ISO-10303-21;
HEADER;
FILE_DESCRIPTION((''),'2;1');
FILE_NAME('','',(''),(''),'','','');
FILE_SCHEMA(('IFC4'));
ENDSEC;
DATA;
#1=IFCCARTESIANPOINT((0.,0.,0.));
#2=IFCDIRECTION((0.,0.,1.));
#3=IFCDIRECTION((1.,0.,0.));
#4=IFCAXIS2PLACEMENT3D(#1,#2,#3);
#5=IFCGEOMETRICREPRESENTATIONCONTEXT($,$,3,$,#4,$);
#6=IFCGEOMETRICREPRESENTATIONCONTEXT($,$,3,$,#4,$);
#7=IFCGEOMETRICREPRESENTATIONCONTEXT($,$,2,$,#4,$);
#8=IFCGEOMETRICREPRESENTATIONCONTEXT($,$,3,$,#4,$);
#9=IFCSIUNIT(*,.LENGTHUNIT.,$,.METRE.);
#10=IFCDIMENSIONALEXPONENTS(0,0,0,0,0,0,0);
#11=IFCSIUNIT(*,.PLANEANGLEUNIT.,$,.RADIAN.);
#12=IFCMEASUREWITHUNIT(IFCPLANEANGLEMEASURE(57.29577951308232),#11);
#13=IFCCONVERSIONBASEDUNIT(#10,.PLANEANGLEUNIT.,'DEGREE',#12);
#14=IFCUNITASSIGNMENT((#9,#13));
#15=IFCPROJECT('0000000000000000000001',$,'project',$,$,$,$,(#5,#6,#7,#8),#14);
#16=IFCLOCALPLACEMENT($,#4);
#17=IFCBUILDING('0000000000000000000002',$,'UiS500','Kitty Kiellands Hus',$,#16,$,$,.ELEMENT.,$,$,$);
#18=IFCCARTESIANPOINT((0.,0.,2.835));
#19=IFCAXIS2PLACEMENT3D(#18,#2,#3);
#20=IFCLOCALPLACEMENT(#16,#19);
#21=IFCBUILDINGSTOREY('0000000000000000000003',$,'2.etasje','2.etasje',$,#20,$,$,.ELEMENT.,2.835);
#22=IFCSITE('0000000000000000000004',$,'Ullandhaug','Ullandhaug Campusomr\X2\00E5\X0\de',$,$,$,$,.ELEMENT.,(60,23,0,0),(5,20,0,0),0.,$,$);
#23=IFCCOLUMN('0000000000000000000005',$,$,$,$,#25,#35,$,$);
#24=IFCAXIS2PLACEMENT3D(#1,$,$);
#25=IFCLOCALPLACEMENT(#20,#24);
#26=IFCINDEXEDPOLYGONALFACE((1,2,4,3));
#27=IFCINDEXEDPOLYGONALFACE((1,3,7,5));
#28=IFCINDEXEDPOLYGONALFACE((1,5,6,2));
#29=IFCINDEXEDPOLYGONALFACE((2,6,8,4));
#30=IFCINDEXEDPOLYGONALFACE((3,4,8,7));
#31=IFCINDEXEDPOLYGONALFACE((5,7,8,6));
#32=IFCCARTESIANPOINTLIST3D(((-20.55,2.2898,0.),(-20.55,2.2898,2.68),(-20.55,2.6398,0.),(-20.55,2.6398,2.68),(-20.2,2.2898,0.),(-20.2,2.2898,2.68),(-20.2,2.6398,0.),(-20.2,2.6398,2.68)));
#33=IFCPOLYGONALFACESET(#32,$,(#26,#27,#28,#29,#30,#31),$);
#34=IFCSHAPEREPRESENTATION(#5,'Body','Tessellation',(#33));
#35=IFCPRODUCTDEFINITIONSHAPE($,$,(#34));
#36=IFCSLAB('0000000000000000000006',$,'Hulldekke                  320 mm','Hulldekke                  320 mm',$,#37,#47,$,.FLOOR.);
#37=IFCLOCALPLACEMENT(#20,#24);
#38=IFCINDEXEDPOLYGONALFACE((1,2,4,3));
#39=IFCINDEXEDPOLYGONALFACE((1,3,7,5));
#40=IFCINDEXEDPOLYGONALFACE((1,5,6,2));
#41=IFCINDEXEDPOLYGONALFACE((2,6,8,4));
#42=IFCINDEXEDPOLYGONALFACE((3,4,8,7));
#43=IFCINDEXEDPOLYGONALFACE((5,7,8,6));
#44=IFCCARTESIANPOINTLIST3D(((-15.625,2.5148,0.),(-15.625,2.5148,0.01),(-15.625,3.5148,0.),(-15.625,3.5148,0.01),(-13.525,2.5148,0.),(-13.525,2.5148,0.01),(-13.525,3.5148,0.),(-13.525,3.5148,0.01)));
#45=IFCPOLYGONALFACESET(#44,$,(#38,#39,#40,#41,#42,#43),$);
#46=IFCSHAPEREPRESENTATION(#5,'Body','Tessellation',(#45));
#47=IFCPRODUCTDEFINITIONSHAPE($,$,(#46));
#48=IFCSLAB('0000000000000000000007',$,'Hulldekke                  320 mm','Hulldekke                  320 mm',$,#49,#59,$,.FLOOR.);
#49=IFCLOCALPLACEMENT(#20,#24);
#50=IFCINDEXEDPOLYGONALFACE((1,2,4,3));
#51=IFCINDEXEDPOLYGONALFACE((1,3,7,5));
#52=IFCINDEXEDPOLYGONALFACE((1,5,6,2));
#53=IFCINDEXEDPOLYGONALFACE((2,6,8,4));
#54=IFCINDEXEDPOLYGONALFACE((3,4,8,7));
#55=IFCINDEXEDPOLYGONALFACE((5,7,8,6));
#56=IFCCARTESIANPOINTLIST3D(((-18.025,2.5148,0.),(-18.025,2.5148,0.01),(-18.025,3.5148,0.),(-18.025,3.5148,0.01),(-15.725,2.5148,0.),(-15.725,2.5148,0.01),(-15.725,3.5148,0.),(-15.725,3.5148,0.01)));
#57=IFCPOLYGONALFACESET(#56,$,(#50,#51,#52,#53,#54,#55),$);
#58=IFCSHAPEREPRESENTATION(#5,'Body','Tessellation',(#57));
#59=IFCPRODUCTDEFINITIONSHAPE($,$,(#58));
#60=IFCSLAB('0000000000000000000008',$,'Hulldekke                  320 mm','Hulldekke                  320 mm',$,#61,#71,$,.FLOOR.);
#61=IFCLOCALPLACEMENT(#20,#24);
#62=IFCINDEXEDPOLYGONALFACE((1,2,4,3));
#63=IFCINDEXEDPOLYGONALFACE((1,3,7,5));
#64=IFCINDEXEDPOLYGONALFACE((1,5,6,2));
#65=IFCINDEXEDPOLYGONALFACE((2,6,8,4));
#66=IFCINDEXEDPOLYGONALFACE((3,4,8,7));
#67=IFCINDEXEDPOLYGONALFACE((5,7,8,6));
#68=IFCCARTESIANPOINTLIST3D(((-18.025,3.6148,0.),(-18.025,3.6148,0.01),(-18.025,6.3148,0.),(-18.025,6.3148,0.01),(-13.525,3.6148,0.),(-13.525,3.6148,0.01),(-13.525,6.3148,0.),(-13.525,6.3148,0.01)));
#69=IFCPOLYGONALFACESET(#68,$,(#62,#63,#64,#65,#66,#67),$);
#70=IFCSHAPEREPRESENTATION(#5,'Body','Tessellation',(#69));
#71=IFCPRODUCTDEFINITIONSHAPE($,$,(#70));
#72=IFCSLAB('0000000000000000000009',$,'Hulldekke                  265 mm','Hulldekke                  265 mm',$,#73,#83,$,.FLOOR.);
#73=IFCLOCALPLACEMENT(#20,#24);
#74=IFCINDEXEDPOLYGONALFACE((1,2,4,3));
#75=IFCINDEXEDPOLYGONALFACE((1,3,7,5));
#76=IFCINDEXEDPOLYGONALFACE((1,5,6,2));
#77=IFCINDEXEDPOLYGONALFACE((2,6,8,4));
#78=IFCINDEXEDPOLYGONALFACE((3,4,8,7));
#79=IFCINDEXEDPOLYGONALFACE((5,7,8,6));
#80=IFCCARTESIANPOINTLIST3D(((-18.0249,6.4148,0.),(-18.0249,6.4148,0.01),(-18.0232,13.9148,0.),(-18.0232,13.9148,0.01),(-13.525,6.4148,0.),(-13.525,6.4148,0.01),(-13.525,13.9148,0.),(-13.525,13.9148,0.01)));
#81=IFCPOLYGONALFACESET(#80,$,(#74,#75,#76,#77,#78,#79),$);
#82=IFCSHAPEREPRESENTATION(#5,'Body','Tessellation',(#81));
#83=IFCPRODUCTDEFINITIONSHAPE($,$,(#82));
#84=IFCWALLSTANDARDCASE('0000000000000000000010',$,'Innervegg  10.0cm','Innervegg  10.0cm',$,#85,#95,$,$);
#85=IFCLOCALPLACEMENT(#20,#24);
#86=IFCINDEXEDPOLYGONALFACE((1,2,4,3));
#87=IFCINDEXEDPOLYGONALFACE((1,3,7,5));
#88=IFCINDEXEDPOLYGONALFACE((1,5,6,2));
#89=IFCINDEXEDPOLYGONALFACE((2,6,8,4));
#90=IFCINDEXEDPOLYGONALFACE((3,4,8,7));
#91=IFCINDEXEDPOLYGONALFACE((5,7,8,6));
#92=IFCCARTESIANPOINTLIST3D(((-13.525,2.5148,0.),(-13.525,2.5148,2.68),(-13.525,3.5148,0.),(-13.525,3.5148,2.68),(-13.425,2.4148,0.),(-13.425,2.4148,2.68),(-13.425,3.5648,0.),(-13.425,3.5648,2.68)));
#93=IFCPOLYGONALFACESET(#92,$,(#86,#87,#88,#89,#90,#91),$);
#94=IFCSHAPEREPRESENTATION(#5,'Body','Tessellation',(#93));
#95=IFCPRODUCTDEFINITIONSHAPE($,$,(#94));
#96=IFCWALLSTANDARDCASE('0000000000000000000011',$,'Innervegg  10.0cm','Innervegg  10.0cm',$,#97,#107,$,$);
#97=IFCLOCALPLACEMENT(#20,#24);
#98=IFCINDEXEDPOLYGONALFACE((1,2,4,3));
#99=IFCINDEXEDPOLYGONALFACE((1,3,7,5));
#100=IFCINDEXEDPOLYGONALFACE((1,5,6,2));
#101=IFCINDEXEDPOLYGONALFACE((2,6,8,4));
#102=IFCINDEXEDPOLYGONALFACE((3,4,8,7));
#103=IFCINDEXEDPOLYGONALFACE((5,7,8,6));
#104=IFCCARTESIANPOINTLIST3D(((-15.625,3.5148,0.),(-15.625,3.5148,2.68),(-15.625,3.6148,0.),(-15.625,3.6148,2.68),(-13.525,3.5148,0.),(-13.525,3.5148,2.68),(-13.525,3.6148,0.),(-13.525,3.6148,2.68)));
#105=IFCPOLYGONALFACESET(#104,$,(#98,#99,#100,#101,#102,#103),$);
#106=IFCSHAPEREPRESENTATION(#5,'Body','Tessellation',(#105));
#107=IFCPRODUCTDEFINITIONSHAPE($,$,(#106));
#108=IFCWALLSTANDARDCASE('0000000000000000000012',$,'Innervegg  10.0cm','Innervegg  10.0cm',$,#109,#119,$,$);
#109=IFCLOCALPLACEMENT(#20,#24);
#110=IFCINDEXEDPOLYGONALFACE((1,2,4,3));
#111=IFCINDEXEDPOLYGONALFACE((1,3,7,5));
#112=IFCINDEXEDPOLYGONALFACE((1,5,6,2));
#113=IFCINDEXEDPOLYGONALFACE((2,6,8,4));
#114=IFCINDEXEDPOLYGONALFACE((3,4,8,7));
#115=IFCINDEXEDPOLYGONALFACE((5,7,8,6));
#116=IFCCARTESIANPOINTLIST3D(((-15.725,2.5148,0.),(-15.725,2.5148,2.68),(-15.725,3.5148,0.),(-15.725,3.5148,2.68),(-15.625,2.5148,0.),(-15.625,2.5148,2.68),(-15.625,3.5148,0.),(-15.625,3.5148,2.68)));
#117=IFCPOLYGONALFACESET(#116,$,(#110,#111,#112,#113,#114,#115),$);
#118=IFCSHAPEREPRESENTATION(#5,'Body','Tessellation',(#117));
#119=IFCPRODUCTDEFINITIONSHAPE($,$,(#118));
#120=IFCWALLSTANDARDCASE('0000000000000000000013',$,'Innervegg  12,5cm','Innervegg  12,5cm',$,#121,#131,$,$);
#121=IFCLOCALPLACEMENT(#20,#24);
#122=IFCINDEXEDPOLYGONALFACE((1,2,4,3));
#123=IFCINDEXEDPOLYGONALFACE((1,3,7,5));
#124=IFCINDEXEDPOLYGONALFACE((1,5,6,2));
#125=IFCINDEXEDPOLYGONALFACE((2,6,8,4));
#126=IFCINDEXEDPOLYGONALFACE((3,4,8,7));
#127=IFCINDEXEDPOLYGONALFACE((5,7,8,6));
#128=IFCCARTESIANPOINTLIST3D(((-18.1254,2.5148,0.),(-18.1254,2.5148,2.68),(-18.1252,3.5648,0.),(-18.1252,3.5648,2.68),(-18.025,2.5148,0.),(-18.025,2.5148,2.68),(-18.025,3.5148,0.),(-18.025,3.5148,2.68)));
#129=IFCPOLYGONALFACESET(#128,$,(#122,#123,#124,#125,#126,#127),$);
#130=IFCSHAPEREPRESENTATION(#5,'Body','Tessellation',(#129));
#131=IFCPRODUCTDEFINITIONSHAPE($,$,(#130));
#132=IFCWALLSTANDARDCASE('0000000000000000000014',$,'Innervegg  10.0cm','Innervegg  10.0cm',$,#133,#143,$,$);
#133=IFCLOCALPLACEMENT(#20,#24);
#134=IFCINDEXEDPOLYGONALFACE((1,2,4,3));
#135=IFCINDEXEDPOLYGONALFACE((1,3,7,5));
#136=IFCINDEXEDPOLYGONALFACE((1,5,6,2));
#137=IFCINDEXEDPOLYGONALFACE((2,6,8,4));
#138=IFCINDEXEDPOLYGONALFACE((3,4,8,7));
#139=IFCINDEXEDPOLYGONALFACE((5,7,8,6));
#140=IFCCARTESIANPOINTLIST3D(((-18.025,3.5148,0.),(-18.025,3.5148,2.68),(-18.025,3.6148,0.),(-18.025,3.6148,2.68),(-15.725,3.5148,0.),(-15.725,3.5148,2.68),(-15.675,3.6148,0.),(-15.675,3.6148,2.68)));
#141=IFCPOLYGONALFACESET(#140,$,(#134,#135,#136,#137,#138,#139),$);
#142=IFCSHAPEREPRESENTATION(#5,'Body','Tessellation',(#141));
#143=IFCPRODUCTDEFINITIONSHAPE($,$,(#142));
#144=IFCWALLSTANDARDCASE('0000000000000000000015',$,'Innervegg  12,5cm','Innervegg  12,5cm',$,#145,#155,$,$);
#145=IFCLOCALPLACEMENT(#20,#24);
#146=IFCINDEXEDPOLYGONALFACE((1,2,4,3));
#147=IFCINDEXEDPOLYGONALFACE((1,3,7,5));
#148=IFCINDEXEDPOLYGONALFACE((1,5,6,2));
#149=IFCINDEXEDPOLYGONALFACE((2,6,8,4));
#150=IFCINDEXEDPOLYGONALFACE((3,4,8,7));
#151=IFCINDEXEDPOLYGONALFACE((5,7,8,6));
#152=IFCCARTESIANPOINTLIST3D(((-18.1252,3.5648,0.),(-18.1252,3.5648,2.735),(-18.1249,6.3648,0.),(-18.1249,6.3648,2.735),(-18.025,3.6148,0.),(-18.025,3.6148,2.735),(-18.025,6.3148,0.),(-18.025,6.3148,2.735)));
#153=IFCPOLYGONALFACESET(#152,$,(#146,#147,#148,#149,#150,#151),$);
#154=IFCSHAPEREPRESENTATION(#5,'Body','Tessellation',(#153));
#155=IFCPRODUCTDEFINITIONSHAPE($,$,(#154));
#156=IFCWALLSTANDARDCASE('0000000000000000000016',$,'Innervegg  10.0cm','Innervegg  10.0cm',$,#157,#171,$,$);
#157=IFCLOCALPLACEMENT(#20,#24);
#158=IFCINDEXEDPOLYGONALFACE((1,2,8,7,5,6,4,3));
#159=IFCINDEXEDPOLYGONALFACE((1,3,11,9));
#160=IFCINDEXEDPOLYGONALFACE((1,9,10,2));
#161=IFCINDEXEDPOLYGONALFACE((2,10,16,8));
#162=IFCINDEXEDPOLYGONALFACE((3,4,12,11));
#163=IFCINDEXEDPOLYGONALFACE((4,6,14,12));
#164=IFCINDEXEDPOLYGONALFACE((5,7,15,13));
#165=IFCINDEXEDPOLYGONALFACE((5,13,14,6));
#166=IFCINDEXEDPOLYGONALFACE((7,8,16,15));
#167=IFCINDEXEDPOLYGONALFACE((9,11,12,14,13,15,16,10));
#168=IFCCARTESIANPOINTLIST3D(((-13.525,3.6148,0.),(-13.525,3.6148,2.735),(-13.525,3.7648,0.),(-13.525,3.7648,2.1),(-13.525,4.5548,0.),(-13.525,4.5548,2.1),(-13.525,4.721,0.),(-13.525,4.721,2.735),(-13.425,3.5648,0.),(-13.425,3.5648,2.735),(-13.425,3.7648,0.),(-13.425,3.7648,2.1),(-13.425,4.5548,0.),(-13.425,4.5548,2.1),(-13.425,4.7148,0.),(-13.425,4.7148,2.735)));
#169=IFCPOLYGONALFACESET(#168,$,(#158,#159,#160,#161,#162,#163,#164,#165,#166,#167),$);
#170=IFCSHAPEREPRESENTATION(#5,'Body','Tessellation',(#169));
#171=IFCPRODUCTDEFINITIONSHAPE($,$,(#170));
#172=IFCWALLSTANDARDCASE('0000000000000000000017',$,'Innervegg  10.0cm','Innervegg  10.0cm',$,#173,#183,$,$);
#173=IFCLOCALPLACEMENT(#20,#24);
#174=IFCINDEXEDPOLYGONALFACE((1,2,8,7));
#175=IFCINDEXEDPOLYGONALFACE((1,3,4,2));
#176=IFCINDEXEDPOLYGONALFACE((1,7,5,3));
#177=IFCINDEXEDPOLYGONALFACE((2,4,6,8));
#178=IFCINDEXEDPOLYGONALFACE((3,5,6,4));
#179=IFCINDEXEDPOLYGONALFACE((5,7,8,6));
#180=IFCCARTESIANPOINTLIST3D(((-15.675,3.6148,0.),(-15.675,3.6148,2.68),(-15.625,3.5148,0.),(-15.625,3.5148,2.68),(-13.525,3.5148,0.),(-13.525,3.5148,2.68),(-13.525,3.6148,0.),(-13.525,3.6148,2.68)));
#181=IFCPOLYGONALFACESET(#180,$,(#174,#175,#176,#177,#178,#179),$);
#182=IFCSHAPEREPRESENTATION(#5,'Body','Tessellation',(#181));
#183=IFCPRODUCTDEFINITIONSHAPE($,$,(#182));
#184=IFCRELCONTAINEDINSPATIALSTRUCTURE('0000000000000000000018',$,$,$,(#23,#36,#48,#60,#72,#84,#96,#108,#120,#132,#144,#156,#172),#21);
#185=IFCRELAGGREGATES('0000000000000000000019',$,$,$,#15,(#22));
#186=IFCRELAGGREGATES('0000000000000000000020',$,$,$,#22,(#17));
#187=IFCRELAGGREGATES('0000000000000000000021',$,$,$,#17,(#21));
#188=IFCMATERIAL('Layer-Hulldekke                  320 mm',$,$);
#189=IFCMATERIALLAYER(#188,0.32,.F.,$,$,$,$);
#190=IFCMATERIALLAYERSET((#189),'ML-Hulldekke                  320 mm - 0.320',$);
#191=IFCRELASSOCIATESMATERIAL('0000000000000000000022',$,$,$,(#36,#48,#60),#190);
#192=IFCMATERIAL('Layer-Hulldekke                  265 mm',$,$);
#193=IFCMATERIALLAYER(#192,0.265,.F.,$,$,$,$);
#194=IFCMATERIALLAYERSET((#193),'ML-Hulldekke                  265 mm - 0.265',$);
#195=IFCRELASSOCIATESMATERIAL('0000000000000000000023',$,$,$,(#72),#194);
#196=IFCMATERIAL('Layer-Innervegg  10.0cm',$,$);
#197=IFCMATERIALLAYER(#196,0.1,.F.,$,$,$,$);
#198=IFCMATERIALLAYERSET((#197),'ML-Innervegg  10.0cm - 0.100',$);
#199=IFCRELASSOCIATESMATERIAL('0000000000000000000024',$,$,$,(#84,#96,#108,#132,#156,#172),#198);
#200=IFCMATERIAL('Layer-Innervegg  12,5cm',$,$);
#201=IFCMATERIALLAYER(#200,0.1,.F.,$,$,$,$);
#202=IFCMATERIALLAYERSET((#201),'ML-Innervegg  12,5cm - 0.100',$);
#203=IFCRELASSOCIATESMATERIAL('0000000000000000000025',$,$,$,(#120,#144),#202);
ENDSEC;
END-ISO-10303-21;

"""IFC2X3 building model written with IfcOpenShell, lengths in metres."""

from ifc_helpers import new_model, entity, si_unit, converted_unit, frame, origin_with_axes, origin_2d_with_axis, place, context, project, spatial, polyline, rectangle, outline, extrude, material, layer, layer_set, layer_usage, element, save


model = new_model("IFC2X3")

# Units and contexts
context_of_model_1 = context(None, 3, world=origin_with_axes())
context_of_model_2 = context(None, 3, world=origin_with_axes())
context_of_model_3 = context(None, 2, world=origin_with_axes())
context_of_model_4 = context(None, 3, world=origin_with_axes())
ifc_project = project(units=[si_unit("LENGTHUNIT", "METRE"), converted_unit("PLANEANGLEUNIT", "DEGREE", entity("IfcPlaneAngleMeasure", 57.29577951308232), si_unit("PLANEANGLEUNIT", "RADIAN"), dimensions=[0, 0, 0, 0, 0, 0, 0])], contexts=[context_of_model_1, context_of_model_2, context_of_model_3, context_of_model_4])

# Site, building, storey
site = spatial("IfcSite", under=ifc_project, Name="Ullandhaug", Description="Ullandhaug Campusområde", CompositionType="ELEMENT", RefLatitude=(60, 23, 0, 0), RefLongitude=(5, 20, 0, 0), RefElevation=0.0)
building_placement = place(None, origin_with_axes())
building = spatial("IfcBuilding", under=site, at=building_placement, Name="UiS500", Description="Kitty Kiellands Hus", CompositionType="ELEMENT")
storey_placement = place(building_placement, frame((0.0, 0.0, 2.835), z_axis=(0.0, 0.0, 1.0), x_axis=(1.0, 0.0, 0.0)))
storey = spatial("IfcBuildingStorey", under=building, at=storey_placement, Name="2.etasje", Description="2.etasje", CompositionType="ELEMENT", Elevation=2.835)

# Column
column_placement = place(storey_placement, frame((-20.375, 2.4648, 0.0), z_axis=(0.0, 0.0, 1.0), x_axis=(1.0, 0.0, 0.0)))
element("IfcColumn", 1, at=column_placement, inside=storey, context=context_of_model_1, shape_type="SweptSolid", body=[
    extrude(rectangle(XDim=0.35, YDim=0.35, at=origin_2d_with_axis()), origin_with_axes(), (0.0, 0.0, 1.0), 2.68),
])

# Slabs
ifc_material_1 = material(Name="Layer-Hulldekke                  320 mm")
ifc_layer_1 = layer(ifc_material_1, 0.32, ventilated=False)
ifc_layer_set_1 = layer_set([ifc_layer_1], Name="ML-Hulldekke                  320 mm - 0.320")
ifc_layer_usage_1 = layer_usage(ifc_layer_set_1, "AXIS2", "POSITIVE", 0.0)
slab_1_placement = place(storey_placement, frame((-15.625, 2.5148, 0.0), z_axis=(0.0, 0.0, 1.0), x_axis=(1.0, 0.0, 0.0)))
element("IfcSlab", 2, at=slab_1_placement, inside=storey, material=ifc_layer_usage_1, Name="Hulldekke                  320 mm", Description="Hulldekke                  320 mm", PredefinedType="FLOOR", context=context_of_model_1, shape_type="SweptSolid", body=[
    extrude(outline(polyline([(0.0, 0.0), (2.1, 0.0), (2.1, 1.0), (0.0, 1.0), (0.0, 0.0)])), origin_with_axes(), (0.0, 0.0, 1.0), 0.01),
])
slab_2_placement = place(storey_placement, frame((-18.025, 3.5148, 0.0), z_axis=(0.0, 0.0, 1.0), x_axis=(1.0, 0.0, 0.0)))
element("IfcSlab", 3, at=slab_2_placement, inside=storey, material=ifc_layer_usage_1, Name="Hulldekke                  320 mm", Description="Hulldekke                  320 mm", PredefinedType="FLOOR", context=context_of_model_1, shape_type="SweptSolid", body=[
    extrude(outline(polyline([(0.0, 0.0), (1.0, 0.0), (1.0, 2.3), (0.0, 2.3), (0.0, 0.0)])), frame((0.0, 0.0, 0.0), z_axis=(0.0, 0.0, 1.0), x_axis=(0.0, -1.0, 0.0)), (0.0, 0.0, 1.0), 0.01),
])
slab_3_placement = place(storey_placement, frame((-18.025, 3.6148, 0.0), z_axis=(0.0, 0.0, 1.0), x_axis=(1.0, 0.0, 0.0)))
element("IfcSlab", 4, at=slab_3_placement, inside=storey, material=ifc_layer_usage_1, Name="Hulldekke                  320 mm", Description="Hulldekke                  320 mm", PredefinedType="FLOOR", context=context_of_model_1, shape_type="SweptSolid", body=[
    extrude(outline(polyline([(0.0, 0.0), (4.5, 0.0), (4.5, 2.7), (0.0, 2.7), (0.0, 0.0)])), origin_with_axes(), (0.0, 0.0, 1.0), 0.01),
])
ifc_material_2 = material(Name="Layer-Hulldekke                  265 mm")
ifc_layer_2 = layer(ifc_material_2, 0.265, ventilated=False)
ifc_layer_set_2 = layer_set([ifc_layer_2], Name="ML-Hulldekke                  265 mm - 0.265")
ifc_layer_usage_2 = layer_usage(ifc_layer_set_2, "AXIS2", "POSITIVE", 0.0)
slab_4_placement = place(storey_placement, frame((-18.0249, 6.4148, 0.0), z_axis=(0.0, 0.0, 1.0), x_axis=(1.0, 0.0, 0.0)))
element("IfcSlab", 5, at=slab_4_placement, inside=storey, material=ifc_layer_usage_2, Name="Hulldekke                  265 mm", Description="Hulldekke                  265 mm", PredefinedType="FLOOR", context=context_of_model_1, shape_type="SweptSolid", body=[
    extrude(outline(polyline([(0.0, 0.0), (4.4999, 0.0), (4.4998, 7.5), (0.0017, 7.5), (0.0, 0.0)])), frame((0.0, 0.0, 0.0), z_axis=(0.0, 0.0, 1.0), x_axis=(1.0, -0.000006, 0.0)), (0.0, 0.0, 1.0), 0.01),
])

# Walls
ifc_material_3 = material(Name="Layer-Innervegg  10.0cm")
ifc_layer_3 = layer(ifc_material_3, 0.1, ventilated=False)
ifc_layer_set_3 = layer_set([ifc_layer_3], Name="ML-Innervegg  10.0cm - 0.100")
ifc_layer_usage_3 = layer_usage(ifc_layer_set_3, "AXIS2", "POSITIVE", 0.0)
wall_1_placement = place(storey_placement, frame((-13.425, 2.4148, 0.0), z_axis=(0.0, 0.0, 1.0), x_axis=(0.0, 1.0, 0.0)))
element("IfcWallStandardCase", 6, at=wall_1_placement, inside=storey, material=ifc_layer_usage_3, Name="Innervegg  10.0cm", Description="Innervegg  10.0cm", context=context_of_model_1, shape_type="SweptSolid", body=[
    extrude(outline(polyline([(0.0, 0.0), (1.15, 0.0), (1.1, 0.1), (0.1, 0.1), (0.0, 0.0)])), frame((0.0, 0.0, 0.0), z_axis=(0.0, 0.0, 1.0), x_axis=(1.0, 0.0, 0.0)), (0.0, 0.0, 1.0), 2.68),
])
wall_2_placement = place(storey_placement, frame((-13.525, 3.6148, 0.0), z_axis=(0.0, 0.0, 1.0), x_axis=(-1.0, 0.0, 0.0)))
element("IfcWallStandardCase", 7, at=wall_2_placement, inside=storey, material=ifc_layer_usage_3, Name="Innervegg  10.0cm", Description="Innervegg  10.0cm", context=context_of_model_1, shape_type="SweptSolid", body=[
    extrude(outline(polyline([(0.0, 0.0), (2.1, 0.0), (2.1, 0.1), (0.0, 0.1), (0.0, 0.0)])), frame((0.0, 0.0, 0.0), z_axis=(0.0, 0.0, 1.0), x_axis=(1.0, 0.0, 0.0)), (0.0, 0.0, 1.0), 2.68),
])
wall_3_placement = place(storey_placement, frame((-15.725, 3.5148, 0.0), z_axis=(0.0, 0.0, 1.0), x_axis=(0.0, -1.0, 0.0)))
element("IfcWallStandardCase", 8, at=wall_3_placement, inside=storey, material=ifc_layer_usage_3, Name="Innervegg  10.0cm", Description="Innervegg  10.0cm", context=context_of_model_1, shape_type="SweptSolid", body=[
    extrude(outline(polyline([(0.0, 0.0), (1.0, 0.0), (1.0, 0.1), (0.0, 0.1), (0.0, 0.0)])), frame((0.0, 0.0, 0.0), z_axis=(0.0, 0.0, 1.0), x_axis=(1.0, 0.0, 0.0)), (0.0, 0.0, 1.0), 2.68),
])
ifc_material_4 = material(Name="Layer-Innervegg  12,5cm")
ifc_layer_4 = layer(ifc_material_4, 0.1, ventilated=False)
ifc_layer_set_4 = layer_set([ifc_layer_4], Name="ML-Innervegg  12,5cm - 0.100")
ifc_layer_usage_4 = layer_usage(ifc_layer_set_4, "AXIS2", "POSITIVE", 0.0)
wall_4_placement = place(storey_placement, frame((-18.1252, 3.5648, 0.0), z_axis=(0.0, 0.0, 1.0), x_axis=(-0.000124, -1.0, 0.0)))
element("IfcWallStandardCase", 9, at=wall_4_placement, inside=storey, material=ifc_layer_usage_4, Name="Innervegg  12,5cm", Description="Innervegg  12,5cm", context=context_of_model_1, shape_type="SweptSolid", body=[
    extrude(outline(polyline([(0.0, 0.0), (1.05, 0.0), (1.05, 0.1004), (0.05, 0.1002), (0.0, 0.0)])), frame((0.0, 0.0, 0.0), z_axis=(0.0, 0.0, 1.0), x_axis=(1.0, 0.0, 0.0)), (0.0, 0.0, 1.0), 2.68),
])
wall_5_placement = place(storey_placement, frame((-15.675, 3.6148, 0.0), z_axis=(0.0, 0.0, 1.0), x_axis=(-1.0, 0.0, 0.0)))
element("IfcWallStandardCase", 10, at=wall_5_placement, inside=storey, material=ifc_layer_usage_3, Name="Innervegg  10.0cm", Description="Innervegg  10.0cm", context=context_of_model_1, shape_type="SweptSolid", body=[
    extrude(outline(polyline([(0.0, 0.0), (2.35, 0.0), (2.35, 0.1), (0.05, 0.1), (0.0, 0.0)])), frame((0.0, 0.0, 0.0), z_axis=(0.0, 0.0, 1.0), x_axis=(1.0, 0.0, 0.0)), (0.0, 0.0, 1.0), 2.68),
])
wall_6_placement = place(storey_placement, frame((-18.025, 3.6148, 0.0), z_axis=(0.0, 0.0, 1.0), x_axis=(0.0, 1.0, 0.0)))
element("IfcWallStandardCase", 11, at=wall_6_placement, inside=storey, material=ifc_layer_usage_4, Name="Innervegg  12,5cm", Description="Innervegg  12,5cm", context=context_of_model_1, shape_type="SweptSolid", body=[
    extrude(outline(polyline([(0.0, 0.0), (2.7, 0.0), (2.75, 0.0999), (-0.05, 0.1002), (0.0, 0.0)])), frame((0.0, 0.0, 0.0), z_axis=(0.0, 0.0, 1.0), x_axis=(1.0, 0.0, 0.0)), (0.0, 0.0, 1.0), 2.735),
])

# Wall, opening
wall_7_placement = place(storey_placement, frame((-13.525, 4.721, 0.0), z_axis=(0.0, 0.0, 1.0), x_axis=(0.0, -1.0, 0.0)))
wall_7 = element("IfcWallStandardCase", 12, at=wall_7_placement, inside=storey, material=ifc_layer_usage_3, Name="Innervegg  10.0cm", Description="Innervegg  10.0cm", context=context_of_model_1, shape_type="SweptSolid", body=[
    extrude(outline(polyline([(0.0, 0.0), (1.1063, 0.0), (1.1562, 0.1), (0.0062, 0.1), (0.0, 0.0)])), frame((0.0, 0.0, 0.0), z_axis=(0.0, 0.0, 1.0), x_axis=(1.0, 0.0, 0.0)), (0.0, 0.0, 1.0), 2.735),
])
opening_1_placement = place(wall_7_placement, frame((0.1663, 0.1, 0.0), z_axis=(0.0, 0.0, 1.0), x_axis=(1.0, 0.0, 0.0)))
element("IfcOpeningElement", 13, at=opening_1_placement, cuts=wall_7, context=context_of_model_1, shape_type="SweptSolid", body=[
    extrude(outline(polyline([(0.0, 0.0), (2.1, 0.0), (2.1, 0.79), (0.0, 0.79), (0.0, 0.0)])), frame((0.0, 0.0, 0.0), z_axis=(0.0, 1.0, 0.0), x_axis=(0.0, 0.0, 1.0)), (0.0, 0.0, -1.0), 0.1),
])

# Wall
wall_8_placement = place(storey_placement, frame((-15.625, 3.5148, 0.0), z_axis=(0.0, 0.0, 1.0), x_axis=(1.0, 0.0, 0.0)))
element("IfcWallStandardCase", 14, at=wall_8_placement, inside=storey, material=ifc_layer_usage_3, Name="Innervegg  10.0cm", Description="Innervegg  10.0cm", context=context_of_model_1, shape_type="SweptSolid", body=[
    extrude(outline(polyline([(0.0, 0.0), (2.1, 0.0), (2.1, 0.1), (-0.05, 0.1), (0.0, 0.0)])), origin_with_axes(), (0.0, 0.0, 1.0), 2.68),
])

save(model, "model.ifc")
